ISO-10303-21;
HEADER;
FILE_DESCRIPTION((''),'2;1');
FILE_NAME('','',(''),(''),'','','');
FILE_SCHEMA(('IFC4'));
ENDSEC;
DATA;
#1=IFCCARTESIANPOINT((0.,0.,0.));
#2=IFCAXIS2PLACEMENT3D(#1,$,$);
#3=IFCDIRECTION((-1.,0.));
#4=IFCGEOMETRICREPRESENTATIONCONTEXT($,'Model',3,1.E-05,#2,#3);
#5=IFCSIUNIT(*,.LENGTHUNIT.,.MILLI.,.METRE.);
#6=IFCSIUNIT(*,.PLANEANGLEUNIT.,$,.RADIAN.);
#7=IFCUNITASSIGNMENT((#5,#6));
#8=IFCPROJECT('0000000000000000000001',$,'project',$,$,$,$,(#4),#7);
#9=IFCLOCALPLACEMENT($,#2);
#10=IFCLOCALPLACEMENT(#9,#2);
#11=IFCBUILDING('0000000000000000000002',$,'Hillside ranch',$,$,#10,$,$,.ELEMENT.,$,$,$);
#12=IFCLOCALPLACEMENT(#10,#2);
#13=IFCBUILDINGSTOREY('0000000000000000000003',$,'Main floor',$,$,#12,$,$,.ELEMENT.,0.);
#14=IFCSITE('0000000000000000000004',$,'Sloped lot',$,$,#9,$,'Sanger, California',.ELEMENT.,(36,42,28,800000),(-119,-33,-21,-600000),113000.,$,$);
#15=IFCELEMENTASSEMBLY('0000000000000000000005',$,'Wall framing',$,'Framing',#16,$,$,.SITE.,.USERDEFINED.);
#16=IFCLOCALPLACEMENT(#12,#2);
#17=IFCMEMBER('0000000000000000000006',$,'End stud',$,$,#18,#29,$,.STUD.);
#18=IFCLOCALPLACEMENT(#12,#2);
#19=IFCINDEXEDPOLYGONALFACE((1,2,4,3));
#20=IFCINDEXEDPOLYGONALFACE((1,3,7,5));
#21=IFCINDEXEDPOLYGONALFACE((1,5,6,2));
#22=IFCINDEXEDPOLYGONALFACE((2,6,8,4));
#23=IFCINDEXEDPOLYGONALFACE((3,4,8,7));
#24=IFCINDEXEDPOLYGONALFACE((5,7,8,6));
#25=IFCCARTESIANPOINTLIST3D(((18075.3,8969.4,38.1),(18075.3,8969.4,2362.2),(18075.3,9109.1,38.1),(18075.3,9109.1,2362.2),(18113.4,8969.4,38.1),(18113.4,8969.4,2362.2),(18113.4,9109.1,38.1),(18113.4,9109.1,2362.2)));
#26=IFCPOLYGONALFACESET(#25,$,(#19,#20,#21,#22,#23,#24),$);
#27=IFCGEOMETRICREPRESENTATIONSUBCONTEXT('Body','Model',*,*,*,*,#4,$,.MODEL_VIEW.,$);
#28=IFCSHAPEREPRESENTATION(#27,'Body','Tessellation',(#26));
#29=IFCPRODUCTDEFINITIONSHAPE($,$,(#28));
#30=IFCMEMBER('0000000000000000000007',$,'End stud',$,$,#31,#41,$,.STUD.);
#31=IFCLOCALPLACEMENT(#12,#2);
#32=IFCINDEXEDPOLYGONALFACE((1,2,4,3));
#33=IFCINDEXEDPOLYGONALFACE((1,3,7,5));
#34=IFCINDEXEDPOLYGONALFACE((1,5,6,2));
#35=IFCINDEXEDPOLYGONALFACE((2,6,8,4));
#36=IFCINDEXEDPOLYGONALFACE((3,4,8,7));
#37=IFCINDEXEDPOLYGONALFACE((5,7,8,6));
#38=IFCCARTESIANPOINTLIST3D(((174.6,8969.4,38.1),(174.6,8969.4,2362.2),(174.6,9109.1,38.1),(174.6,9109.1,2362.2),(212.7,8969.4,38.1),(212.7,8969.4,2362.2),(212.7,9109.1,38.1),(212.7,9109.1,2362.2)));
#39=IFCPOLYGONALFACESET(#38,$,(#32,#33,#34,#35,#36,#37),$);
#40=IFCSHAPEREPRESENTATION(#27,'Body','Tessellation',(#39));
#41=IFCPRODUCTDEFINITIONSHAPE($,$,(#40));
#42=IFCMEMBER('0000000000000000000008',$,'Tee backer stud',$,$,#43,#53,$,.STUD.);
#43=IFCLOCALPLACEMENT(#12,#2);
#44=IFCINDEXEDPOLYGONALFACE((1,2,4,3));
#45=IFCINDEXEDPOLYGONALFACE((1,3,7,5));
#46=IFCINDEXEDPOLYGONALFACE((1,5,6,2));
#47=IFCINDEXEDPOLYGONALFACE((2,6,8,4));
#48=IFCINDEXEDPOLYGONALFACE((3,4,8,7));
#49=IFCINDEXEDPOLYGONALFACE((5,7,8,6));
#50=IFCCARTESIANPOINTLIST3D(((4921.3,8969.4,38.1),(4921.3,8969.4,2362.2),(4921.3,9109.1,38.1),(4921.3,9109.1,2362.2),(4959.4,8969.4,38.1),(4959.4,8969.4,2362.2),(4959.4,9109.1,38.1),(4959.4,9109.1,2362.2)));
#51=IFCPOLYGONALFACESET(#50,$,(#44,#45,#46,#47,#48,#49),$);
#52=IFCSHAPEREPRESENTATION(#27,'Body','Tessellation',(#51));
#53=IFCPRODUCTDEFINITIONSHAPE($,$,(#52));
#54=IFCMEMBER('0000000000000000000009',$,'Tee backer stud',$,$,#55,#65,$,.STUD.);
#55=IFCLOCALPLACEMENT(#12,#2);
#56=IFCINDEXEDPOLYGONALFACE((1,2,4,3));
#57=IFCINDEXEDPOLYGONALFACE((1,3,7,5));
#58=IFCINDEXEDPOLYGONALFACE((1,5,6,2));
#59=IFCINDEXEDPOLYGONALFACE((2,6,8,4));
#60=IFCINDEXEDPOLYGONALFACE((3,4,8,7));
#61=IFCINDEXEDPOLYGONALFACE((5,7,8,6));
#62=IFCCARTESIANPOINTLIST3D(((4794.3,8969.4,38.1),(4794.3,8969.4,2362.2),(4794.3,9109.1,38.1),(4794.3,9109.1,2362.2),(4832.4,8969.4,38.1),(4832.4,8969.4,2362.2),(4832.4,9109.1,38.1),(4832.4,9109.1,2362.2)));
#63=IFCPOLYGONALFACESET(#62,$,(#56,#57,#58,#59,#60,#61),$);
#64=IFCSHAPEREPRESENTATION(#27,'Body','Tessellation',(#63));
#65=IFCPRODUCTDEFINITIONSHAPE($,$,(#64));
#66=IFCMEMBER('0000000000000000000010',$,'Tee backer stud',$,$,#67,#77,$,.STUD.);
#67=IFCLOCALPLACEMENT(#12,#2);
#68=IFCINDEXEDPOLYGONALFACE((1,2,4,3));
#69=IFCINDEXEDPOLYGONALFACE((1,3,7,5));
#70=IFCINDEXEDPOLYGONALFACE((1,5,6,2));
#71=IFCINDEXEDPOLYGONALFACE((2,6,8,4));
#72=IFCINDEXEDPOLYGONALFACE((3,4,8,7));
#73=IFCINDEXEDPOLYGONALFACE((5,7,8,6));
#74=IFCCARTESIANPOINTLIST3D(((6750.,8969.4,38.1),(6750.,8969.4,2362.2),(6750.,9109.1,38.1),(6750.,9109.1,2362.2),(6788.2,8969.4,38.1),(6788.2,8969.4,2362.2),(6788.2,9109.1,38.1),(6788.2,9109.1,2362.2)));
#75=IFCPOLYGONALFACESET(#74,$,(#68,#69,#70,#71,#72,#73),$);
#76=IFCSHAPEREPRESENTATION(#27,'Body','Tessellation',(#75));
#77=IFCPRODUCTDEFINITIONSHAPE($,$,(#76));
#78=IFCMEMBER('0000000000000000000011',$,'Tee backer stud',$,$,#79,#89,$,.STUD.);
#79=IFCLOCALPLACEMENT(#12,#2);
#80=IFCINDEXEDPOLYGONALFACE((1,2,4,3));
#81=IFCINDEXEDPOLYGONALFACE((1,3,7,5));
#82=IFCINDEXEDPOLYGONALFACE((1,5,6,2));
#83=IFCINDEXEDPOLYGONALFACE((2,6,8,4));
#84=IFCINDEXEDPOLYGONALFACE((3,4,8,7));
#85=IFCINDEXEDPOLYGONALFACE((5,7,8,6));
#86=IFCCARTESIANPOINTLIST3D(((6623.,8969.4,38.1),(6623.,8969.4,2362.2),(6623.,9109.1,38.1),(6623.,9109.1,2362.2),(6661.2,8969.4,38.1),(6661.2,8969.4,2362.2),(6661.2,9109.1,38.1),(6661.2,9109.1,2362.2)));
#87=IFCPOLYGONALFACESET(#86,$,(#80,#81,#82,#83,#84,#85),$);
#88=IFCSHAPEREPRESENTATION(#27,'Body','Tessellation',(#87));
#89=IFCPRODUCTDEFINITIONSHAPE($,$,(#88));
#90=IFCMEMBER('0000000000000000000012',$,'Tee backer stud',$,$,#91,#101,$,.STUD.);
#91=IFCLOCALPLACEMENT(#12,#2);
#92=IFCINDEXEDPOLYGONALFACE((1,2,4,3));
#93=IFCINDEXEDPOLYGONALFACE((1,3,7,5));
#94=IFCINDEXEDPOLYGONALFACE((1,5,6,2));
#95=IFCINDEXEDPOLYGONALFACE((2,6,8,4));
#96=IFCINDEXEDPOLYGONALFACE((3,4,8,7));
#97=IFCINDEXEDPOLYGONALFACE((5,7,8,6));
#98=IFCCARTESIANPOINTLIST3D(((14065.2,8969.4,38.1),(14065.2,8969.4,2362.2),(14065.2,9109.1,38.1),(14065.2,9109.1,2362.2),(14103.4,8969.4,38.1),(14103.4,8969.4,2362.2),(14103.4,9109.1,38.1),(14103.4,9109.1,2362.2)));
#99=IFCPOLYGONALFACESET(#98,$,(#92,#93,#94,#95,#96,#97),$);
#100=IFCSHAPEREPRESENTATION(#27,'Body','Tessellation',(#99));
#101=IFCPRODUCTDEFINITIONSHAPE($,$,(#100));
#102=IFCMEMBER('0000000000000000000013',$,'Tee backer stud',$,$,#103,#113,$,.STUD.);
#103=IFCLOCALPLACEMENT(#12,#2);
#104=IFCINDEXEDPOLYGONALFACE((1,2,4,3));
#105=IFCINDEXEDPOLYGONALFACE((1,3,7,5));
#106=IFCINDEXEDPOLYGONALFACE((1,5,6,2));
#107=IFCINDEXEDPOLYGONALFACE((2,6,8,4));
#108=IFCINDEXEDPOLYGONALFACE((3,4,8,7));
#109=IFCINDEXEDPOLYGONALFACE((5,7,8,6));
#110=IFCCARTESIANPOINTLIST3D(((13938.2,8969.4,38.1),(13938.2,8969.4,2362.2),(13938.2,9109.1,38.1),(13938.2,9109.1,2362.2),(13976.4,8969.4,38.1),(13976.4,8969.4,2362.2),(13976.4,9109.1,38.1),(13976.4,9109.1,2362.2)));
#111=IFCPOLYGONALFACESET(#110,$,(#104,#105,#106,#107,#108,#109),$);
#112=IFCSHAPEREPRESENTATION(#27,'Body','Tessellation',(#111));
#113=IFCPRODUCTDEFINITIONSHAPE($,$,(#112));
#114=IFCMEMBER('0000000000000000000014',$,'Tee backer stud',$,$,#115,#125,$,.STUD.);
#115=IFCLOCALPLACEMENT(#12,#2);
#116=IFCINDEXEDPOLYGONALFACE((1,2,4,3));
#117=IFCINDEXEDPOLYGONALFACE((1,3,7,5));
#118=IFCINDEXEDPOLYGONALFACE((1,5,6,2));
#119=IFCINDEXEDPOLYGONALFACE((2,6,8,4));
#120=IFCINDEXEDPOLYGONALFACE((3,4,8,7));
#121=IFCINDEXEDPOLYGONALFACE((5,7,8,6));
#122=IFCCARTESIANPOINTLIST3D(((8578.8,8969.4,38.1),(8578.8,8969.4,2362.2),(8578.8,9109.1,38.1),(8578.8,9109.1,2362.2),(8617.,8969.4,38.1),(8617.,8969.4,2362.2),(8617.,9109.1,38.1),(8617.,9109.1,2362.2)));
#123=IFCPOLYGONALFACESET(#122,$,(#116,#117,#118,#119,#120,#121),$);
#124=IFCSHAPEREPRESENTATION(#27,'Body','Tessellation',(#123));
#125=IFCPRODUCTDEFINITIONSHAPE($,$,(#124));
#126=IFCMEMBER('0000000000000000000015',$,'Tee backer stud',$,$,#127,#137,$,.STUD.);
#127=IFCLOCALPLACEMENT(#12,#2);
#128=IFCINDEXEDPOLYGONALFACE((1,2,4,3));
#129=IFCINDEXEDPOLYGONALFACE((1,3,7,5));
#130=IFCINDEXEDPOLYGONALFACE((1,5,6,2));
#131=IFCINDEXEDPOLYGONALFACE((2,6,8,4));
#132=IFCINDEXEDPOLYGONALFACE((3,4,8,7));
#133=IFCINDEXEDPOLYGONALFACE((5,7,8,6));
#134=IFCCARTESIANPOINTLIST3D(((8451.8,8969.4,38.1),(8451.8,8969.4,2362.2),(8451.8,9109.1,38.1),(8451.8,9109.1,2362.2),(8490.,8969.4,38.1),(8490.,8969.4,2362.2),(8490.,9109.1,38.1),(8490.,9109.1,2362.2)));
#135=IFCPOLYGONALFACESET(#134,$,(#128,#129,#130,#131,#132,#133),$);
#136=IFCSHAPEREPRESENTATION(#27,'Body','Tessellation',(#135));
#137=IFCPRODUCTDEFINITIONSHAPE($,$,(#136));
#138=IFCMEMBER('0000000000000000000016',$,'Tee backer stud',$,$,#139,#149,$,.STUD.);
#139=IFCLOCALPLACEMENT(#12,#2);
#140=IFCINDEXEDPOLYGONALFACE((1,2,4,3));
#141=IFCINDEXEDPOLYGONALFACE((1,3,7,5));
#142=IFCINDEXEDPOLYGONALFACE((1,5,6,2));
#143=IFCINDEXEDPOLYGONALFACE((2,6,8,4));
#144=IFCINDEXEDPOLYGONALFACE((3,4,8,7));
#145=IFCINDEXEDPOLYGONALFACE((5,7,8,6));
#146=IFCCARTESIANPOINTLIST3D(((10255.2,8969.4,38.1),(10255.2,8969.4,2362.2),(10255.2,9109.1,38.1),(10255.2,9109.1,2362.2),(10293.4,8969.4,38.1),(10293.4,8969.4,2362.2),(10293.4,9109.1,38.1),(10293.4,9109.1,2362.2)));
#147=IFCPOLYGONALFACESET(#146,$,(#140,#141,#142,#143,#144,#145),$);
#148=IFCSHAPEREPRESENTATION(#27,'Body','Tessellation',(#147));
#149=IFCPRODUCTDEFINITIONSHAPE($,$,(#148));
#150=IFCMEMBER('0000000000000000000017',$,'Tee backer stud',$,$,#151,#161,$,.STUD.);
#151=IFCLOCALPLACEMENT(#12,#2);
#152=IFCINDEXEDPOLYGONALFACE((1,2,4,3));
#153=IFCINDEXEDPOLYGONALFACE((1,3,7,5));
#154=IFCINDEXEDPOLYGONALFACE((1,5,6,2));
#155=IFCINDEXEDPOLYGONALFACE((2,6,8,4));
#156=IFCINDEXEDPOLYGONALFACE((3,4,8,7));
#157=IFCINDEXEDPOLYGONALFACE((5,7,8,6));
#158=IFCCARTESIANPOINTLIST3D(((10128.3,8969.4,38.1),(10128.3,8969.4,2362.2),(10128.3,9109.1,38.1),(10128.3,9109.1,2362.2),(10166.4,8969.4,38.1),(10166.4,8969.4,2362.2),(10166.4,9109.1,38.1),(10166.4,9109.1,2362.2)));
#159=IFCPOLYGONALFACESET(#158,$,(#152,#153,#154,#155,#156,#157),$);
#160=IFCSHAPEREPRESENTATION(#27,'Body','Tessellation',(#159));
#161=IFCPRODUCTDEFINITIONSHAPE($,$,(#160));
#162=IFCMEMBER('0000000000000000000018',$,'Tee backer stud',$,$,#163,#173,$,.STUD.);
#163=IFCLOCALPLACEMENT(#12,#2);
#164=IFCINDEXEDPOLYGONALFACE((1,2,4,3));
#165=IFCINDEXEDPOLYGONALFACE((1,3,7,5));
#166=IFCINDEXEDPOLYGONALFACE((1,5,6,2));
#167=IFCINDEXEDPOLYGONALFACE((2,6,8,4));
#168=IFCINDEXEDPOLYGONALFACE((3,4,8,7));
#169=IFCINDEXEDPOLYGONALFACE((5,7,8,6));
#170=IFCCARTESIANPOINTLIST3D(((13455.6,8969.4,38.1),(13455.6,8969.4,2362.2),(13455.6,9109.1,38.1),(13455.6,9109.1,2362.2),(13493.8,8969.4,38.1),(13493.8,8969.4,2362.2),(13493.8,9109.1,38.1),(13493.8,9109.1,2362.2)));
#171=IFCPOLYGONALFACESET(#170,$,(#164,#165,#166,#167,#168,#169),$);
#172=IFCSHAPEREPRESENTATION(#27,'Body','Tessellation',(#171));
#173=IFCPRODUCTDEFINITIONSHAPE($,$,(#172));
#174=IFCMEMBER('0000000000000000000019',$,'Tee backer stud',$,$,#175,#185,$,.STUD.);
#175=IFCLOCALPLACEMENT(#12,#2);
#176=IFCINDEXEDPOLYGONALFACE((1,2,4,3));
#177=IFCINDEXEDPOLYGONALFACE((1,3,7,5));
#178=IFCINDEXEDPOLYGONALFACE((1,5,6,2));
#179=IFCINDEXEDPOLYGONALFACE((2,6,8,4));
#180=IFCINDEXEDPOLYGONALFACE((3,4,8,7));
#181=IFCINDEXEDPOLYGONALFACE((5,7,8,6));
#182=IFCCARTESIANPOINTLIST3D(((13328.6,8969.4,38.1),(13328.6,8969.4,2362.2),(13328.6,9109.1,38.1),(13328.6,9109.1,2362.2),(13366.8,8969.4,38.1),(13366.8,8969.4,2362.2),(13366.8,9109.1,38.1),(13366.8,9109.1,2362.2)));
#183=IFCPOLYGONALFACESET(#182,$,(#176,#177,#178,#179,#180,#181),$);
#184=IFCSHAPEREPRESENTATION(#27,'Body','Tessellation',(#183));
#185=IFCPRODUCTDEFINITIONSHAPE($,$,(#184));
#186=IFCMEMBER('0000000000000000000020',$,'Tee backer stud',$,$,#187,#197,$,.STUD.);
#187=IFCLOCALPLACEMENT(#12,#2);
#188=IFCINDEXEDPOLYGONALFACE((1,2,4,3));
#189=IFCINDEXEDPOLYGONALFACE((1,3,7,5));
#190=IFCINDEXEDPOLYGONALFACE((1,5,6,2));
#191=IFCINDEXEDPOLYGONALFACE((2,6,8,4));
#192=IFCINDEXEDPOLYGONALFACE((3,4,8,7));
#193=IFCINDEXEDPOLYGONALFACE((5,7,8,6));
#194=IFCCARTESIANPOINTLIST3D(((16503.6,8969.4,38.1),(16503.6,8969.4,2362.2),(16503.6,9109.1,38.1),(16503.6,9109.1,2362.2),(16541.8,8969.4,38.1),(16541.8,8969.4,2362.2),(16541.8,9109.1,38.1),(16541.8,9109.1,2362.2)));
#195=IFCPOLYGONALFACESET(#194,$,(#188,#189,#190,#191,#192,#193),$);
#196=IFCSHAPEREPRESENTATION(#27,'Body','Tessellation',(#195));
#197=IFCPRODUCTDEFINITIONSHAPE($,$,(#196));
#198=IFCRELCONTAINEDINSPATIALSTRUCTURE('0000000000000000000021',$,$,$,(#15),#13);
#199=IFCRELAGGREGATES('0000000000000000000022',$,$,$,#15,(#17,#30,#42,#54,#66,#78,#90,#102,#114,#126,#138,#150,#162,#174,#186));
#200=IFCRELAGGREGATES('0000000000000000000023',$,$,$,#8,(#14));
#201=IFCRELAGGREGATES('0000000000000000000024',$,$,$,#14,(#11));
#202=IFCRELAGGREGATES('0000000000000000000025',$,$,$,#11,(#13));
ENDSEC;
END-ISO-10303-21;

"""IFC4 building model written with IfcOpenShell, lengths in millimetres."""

from ifc_helpers import new_model, si_unit, direction, frame, origin, origin_with_axes, place, context, subcontext, project, spatial, polyline, outline, extrude, element, aggregate, save


model = new_model("IFC4")

# Units and contexts
model_context = context("Model", 3, precision=1e-05, world=origin(), true_north=direction((-1.0, 0.0)))
body_context = subcontext(model_context, "Body", "Model", "MODEL_VIEW")
ifc_project = project(units=[si_unit("LENGTHUNIT", "METRE", prefix="MILLI"), si_unit("PLANEANGLEUNIT", "RADIAN")], contexts=[model_context])

# Site, building, storey
site_placement = place(None, origin())
site = spatial("IfcSite", under=ifc_project, at=site_placement, Name="Sloped lot", LongName="Sanger, California", CompositionType="ELEMENT", RefLatitude=(36, 42, 28, 800000), RefLongitude=(-119, -33, -21, -600000), RefElevation=113000.0)
building_placement = place(site_placement, origin())
building = spatial("IfcBuilding", under=site, at=building_placement, Name="Hillside ranch", CompositionType="ELEMENT")
storey_placement = place(building_placement, origin())
storey = spatial("IfcBuildingStorey", under=building, at=storey_placement, Name="Main floor", CompositionType="ELEMENT", Elevation=0.0)

# Element assembly, members
assembly_placement = place(storey_placement, origin_with_axes())
assembly = element("IfcElementAssembly", 1, at=assembly_placement, inside=storey, Name="Wall framing", ObjectType="Framing", AssemblyPlace="SITE", PredefinedType="USERDEFINED")
member_1_placement = place(storey_placement, origin_with_axes())
member_1 = element("IfcMember", 2, at=member_1_placement, Name="End stud", PredefinedType="STUD", context=body_context, shape_type="SweptSolid", body=[
    extrude(outline(polyline([(0.0, 0.0), (38.1, 0.0), (38.1, 139.7), (0.0, 139.7), (0.0, 0.0)])), frame((18113.4, 9109.1, 38.1), z_axis=(0.0, 0.0, 1.0), x_axis=(-1.0, 0.0, 0.0)), (0.0, 0.0, 1.0), 2324.1),
])
member_2_placement = place(storey_placement, origin_with_axes())
member_2 = element("IfcMember", 3, at=member_2_placement, Name="End stud", PredefinedType="STUD", context=body_context, shape_type="SweptSolid", body=[
    extrude(outline(polyline([(0.0, 0.0), (38.1, 0.0), (38.1, 139.7), (0.0, 139.7), (0.0, 0.0)])), frame((212.7, 9109.1, 38.1), z_axis=(0.0, 0.0, 1.0), x_axis=(-1.0, 0.0, 0.0)), (0.0, 0.0, 1.0), 2324.1),
])
member_3_placement = place(storey_placement, origin_with_axes())
member_3 = element("IfcMember", 4, at=member_3_placement, Name="Tee backer stud", PredefinedType="STUD", context=body_context, shape_type="SweptSolid", body=[
    extrude(outline(polyline([(0.0, 0.0), (38.1, 0.0), (38.1, 139.7), (0.0, 139.7), (0.0, 0.0)])), frame((4959.4, 9109.1, 38.1), z_axis=(0.0, 0.0, 1.0), x_axis=(-1.0, 0.0, 0.0)), (0.0, 0.0, 1.0), 2324.1),
])
member_4_placement = place(storey_placement, origin_with_axes())
member_4 = element("IfcMember", 5, at=member_4_placement, Name="Tee backer stud", PredefinedType="STUD", context=body_context, shape_type="SweptSolid", body=[
    extrude(outline(polyline([(0.0, 0.0), (38.1, 0.0), (38.1, 139.7), (0.0, 139.7), (0.0, 0.0)])), frame((4832.4, 9109.1, 38.1), z_axis=(0.0, 0.0, 1.0), x_axis=(-1.0, 0.0, 0.0)), (0.0, 0.0, 1.0), 2324.1),
])
member_5_placement = place(storey_placement, origin_with_axes())
member_5 = element("IfcMember", 6, at=member_5_placement, Name="Tee backer stud", PredefinedType="STUD", context=body_context, shape_type="SweptSolid", body=[
    extrude(outline(polyline([(0.0, 0.0), (38.1, 0.0), (38.1, 139.7), (0.0, 139.7), (0.0, 0.0)])), frame((6788.1, 9109.1, 38.1), z_axis=(0.0, 0.0, 1.0), x_axis=(-1.0, 0.0, 0.0)), (0.0, 0.0, 1.0), 2324.1),
])
member_6_placement = place(storey_placement, origin_with_axes())
member_6 = element("IfcMember", 7, at=member_6_placement, Name="Tee backer stud", PredefinedType="STUD", context=body_context, shape_type="SweptSolid", body=[
    extrude(outline(polyline([(0.0, 0.0), (38.1, 0.0), (38.1, 139.7), (0.0, 139.7), (0.0, 0.0)])), frame((6661.1, 9109.1, 38.1), z_axis=(0.0, 0.0, 1.0), x_axis=(-1.0, 0.0, 0.0)), (0.0, 0.0, 1.0), 2324.1),
])
member_7_placement = place(storey_placement, origin_with_axes())
member_7 = element("IfcMember", 8, at=member_7_placement, Name="Tee backer stud", PredefinedType="STUD", context=body_context, shape_type="SweptSolid", body=[
    extrude(outline(polyline([(0.0, 0.0), (38.1, 0.0), (38.1, 139.7), (0.0, 139.7), (0.0, 0.0)])), frame((14103.4, 9109.1, 38.1), z_axis=(0.0, 0.0, 1.0), x_axis=(-1.0, 0.0, 0.0)), (0.0, 0.0, 1.0), 2324.1),
])
member_8_placement = place(storey_placement, origin_with_axes())
member_8 = element("IfcMember", 9, at=member_8_placement, Name="Tee backer stud", PredefinedType="STUD", context=body_context, shape_type="SweptSolid", body=[
    extrude(outline(polyline([(0.0, 0.0), (38.1, 0.0), (38.1, 139.7), (0.0, 139.7), (0.0, 0.0)])), frame((13976.4, 9109.1, 38.1), z_axis=(0.0, 0.0, 1.0), x_axis=(-1.0, 0.0, 0.0)), (0.0, 0.0, 1.0), 2324.1),
])
member_9_placement = place(storey_placement, origin_with_axes())
member_9 = element("IfcMember", 10, at=member_9_placement, Name="Tee backer stud", PredefinedType="STUD", context=body_context, shape_type="SweptSolid", body=[
    extrude(outline(polyline([(0.0, 0.0), (38.1, 0.0), (38.1, 139.7), (0.0, 139.7), (0.0, 0.0)])), frame((8617.0, 9109.1, 38.1), z_axis=(0.0, 0.0, 1.0), x_axis=(-1.0, 0.0, 0.0)), (0.0, 0.0, 1.0), 2324.1),
])
member_10_placement = place(storey_placement, origin_with_axes())
member_10 = element("IfcMember", 11, at=member_10_placement, Name="Tee backer stud", PredefinedType="STUD", context=body_context, shape_type="SweptSolid", body=[
    extrude(outline(polyline([(0.0, 0.0), (38.1, 0.0), (38.1, 139.7), (0.0, 139.7), (0.0, 0.0)])), frame((8490.0, 9109.1, 38.1), z_axis=(0.0, 0.0, 1.0), x_axis=(-1.0, 0.0, 0.0)), (0.0, 0.0, 1.0), 2324.1),
])
member_11_placement = place(storey_placement, origin_with_axes())
member_11 = element("IfcMember", 12, at=member_11_placement, Name="Tee backer stud", PredefinedType="STUD", context=body_context, shape_type="SweptSolid", body=[
    extrude(outline(polyline([(0.0, 0.0), (38.1, 0.0), (38.1, 139.7), (0.0, 139.7), (0.0, 0.0)])), frame((10293.4, 9109.1, 38.1), z_axis=(0.0, 0.0, 1.0), x_axis=(-1.0, 0.0, 0.0)), (0.0, 0.0, 1.0), 2324.1),
])
member_12_placement = place(storey_placement, origin_with_axes())
member_12 = element("IfcMember", 13, at=member_12_placement, Name="Tee backer stud", PredefinedType="STUD", context=body_context, shape_type="SweptSolid", body=[
    extrude(outline(polyline([(0.0, 0.0), (38.1, 0.0), (38.1, 139.7), (0.0, 139.7), (0.0, 0.0)])), frame((10166.4, 9109.1, 38.1), z_axis=(0.0, 0.0, 1.0), x_axis=(-1.0, 0.0, 0.0)), (0.0, 0.0, 1.0), 2324.1),
])
member_13_placement = place(storey_placement, origin_with_axes())
member_13 = element("IfcMember", 14, at=member_13_placement, Name="Tee backer stud", PredefinedType="STUD", context=body_context, shape_type="SweptSolid", body=[
    extrude(outline(polyline([(0.0, 0.0), (38.1, 0.0), (38.1, 139.7), (0.0, 139.7), (0.0, 0.0)])), frame((13493.8, 9109.1, 38.1), z_axis=(0.0, 0.0, 1.0), x_axis=(-1.0, 0.0, 0.0)), (0.0, 0.0, 1.0), 2324.1),
])
member_14_placement = place(storey_placement, origin_with_axes())
member_14 = element("IfcMember", 15, at=member_14_placement, Name="Tee backer stud", PredefinedType="STUD", context=body_context, shape_type="SweptSolid", body=[
    extrude(outline(polyline([(0.0, 0.0), (38.1, 0.0), (38.1, 139.7), (0.0, 139.7), (0.0, 0.0)])), frame((13366.8, 9109.1, 38.1), z_axis=(0.0, 0.0, 1.0), x_axis=(-1.0, 0.0, 0.0)), (0.0, 0.0, 1.0), 2324.1),
])
member_15_placement = place(storey_placement, origin_with_axes())
member_15 = element("IfcMember", 16, at=member_15_placement, Name="Tee backer stud", PredefinedType="STUD", context=body_context, shape_type="SweptSolid", body=[
    extrude(outline(polyline([(0.0, 0.0), (38.1, 0.0), (38.1, 139.7), (0.0, 139.7), (0.0, 0.0)])), frame((16541.8, 9109.1, 38.1), z_axis=(0.0, 0.0, 1.0), x_axis=(-1.0, 0.0, 0.0)), (0.0, 0.0, 1.0), 2324.1),
])
aggregate(assembly, [member_1, member_2, member_3, member_4, member_5, member_6, member_7, member_8, member_9, member_10, member_11, member_12, member_13, member_14, member_15])

save(model, "model.ifc")
